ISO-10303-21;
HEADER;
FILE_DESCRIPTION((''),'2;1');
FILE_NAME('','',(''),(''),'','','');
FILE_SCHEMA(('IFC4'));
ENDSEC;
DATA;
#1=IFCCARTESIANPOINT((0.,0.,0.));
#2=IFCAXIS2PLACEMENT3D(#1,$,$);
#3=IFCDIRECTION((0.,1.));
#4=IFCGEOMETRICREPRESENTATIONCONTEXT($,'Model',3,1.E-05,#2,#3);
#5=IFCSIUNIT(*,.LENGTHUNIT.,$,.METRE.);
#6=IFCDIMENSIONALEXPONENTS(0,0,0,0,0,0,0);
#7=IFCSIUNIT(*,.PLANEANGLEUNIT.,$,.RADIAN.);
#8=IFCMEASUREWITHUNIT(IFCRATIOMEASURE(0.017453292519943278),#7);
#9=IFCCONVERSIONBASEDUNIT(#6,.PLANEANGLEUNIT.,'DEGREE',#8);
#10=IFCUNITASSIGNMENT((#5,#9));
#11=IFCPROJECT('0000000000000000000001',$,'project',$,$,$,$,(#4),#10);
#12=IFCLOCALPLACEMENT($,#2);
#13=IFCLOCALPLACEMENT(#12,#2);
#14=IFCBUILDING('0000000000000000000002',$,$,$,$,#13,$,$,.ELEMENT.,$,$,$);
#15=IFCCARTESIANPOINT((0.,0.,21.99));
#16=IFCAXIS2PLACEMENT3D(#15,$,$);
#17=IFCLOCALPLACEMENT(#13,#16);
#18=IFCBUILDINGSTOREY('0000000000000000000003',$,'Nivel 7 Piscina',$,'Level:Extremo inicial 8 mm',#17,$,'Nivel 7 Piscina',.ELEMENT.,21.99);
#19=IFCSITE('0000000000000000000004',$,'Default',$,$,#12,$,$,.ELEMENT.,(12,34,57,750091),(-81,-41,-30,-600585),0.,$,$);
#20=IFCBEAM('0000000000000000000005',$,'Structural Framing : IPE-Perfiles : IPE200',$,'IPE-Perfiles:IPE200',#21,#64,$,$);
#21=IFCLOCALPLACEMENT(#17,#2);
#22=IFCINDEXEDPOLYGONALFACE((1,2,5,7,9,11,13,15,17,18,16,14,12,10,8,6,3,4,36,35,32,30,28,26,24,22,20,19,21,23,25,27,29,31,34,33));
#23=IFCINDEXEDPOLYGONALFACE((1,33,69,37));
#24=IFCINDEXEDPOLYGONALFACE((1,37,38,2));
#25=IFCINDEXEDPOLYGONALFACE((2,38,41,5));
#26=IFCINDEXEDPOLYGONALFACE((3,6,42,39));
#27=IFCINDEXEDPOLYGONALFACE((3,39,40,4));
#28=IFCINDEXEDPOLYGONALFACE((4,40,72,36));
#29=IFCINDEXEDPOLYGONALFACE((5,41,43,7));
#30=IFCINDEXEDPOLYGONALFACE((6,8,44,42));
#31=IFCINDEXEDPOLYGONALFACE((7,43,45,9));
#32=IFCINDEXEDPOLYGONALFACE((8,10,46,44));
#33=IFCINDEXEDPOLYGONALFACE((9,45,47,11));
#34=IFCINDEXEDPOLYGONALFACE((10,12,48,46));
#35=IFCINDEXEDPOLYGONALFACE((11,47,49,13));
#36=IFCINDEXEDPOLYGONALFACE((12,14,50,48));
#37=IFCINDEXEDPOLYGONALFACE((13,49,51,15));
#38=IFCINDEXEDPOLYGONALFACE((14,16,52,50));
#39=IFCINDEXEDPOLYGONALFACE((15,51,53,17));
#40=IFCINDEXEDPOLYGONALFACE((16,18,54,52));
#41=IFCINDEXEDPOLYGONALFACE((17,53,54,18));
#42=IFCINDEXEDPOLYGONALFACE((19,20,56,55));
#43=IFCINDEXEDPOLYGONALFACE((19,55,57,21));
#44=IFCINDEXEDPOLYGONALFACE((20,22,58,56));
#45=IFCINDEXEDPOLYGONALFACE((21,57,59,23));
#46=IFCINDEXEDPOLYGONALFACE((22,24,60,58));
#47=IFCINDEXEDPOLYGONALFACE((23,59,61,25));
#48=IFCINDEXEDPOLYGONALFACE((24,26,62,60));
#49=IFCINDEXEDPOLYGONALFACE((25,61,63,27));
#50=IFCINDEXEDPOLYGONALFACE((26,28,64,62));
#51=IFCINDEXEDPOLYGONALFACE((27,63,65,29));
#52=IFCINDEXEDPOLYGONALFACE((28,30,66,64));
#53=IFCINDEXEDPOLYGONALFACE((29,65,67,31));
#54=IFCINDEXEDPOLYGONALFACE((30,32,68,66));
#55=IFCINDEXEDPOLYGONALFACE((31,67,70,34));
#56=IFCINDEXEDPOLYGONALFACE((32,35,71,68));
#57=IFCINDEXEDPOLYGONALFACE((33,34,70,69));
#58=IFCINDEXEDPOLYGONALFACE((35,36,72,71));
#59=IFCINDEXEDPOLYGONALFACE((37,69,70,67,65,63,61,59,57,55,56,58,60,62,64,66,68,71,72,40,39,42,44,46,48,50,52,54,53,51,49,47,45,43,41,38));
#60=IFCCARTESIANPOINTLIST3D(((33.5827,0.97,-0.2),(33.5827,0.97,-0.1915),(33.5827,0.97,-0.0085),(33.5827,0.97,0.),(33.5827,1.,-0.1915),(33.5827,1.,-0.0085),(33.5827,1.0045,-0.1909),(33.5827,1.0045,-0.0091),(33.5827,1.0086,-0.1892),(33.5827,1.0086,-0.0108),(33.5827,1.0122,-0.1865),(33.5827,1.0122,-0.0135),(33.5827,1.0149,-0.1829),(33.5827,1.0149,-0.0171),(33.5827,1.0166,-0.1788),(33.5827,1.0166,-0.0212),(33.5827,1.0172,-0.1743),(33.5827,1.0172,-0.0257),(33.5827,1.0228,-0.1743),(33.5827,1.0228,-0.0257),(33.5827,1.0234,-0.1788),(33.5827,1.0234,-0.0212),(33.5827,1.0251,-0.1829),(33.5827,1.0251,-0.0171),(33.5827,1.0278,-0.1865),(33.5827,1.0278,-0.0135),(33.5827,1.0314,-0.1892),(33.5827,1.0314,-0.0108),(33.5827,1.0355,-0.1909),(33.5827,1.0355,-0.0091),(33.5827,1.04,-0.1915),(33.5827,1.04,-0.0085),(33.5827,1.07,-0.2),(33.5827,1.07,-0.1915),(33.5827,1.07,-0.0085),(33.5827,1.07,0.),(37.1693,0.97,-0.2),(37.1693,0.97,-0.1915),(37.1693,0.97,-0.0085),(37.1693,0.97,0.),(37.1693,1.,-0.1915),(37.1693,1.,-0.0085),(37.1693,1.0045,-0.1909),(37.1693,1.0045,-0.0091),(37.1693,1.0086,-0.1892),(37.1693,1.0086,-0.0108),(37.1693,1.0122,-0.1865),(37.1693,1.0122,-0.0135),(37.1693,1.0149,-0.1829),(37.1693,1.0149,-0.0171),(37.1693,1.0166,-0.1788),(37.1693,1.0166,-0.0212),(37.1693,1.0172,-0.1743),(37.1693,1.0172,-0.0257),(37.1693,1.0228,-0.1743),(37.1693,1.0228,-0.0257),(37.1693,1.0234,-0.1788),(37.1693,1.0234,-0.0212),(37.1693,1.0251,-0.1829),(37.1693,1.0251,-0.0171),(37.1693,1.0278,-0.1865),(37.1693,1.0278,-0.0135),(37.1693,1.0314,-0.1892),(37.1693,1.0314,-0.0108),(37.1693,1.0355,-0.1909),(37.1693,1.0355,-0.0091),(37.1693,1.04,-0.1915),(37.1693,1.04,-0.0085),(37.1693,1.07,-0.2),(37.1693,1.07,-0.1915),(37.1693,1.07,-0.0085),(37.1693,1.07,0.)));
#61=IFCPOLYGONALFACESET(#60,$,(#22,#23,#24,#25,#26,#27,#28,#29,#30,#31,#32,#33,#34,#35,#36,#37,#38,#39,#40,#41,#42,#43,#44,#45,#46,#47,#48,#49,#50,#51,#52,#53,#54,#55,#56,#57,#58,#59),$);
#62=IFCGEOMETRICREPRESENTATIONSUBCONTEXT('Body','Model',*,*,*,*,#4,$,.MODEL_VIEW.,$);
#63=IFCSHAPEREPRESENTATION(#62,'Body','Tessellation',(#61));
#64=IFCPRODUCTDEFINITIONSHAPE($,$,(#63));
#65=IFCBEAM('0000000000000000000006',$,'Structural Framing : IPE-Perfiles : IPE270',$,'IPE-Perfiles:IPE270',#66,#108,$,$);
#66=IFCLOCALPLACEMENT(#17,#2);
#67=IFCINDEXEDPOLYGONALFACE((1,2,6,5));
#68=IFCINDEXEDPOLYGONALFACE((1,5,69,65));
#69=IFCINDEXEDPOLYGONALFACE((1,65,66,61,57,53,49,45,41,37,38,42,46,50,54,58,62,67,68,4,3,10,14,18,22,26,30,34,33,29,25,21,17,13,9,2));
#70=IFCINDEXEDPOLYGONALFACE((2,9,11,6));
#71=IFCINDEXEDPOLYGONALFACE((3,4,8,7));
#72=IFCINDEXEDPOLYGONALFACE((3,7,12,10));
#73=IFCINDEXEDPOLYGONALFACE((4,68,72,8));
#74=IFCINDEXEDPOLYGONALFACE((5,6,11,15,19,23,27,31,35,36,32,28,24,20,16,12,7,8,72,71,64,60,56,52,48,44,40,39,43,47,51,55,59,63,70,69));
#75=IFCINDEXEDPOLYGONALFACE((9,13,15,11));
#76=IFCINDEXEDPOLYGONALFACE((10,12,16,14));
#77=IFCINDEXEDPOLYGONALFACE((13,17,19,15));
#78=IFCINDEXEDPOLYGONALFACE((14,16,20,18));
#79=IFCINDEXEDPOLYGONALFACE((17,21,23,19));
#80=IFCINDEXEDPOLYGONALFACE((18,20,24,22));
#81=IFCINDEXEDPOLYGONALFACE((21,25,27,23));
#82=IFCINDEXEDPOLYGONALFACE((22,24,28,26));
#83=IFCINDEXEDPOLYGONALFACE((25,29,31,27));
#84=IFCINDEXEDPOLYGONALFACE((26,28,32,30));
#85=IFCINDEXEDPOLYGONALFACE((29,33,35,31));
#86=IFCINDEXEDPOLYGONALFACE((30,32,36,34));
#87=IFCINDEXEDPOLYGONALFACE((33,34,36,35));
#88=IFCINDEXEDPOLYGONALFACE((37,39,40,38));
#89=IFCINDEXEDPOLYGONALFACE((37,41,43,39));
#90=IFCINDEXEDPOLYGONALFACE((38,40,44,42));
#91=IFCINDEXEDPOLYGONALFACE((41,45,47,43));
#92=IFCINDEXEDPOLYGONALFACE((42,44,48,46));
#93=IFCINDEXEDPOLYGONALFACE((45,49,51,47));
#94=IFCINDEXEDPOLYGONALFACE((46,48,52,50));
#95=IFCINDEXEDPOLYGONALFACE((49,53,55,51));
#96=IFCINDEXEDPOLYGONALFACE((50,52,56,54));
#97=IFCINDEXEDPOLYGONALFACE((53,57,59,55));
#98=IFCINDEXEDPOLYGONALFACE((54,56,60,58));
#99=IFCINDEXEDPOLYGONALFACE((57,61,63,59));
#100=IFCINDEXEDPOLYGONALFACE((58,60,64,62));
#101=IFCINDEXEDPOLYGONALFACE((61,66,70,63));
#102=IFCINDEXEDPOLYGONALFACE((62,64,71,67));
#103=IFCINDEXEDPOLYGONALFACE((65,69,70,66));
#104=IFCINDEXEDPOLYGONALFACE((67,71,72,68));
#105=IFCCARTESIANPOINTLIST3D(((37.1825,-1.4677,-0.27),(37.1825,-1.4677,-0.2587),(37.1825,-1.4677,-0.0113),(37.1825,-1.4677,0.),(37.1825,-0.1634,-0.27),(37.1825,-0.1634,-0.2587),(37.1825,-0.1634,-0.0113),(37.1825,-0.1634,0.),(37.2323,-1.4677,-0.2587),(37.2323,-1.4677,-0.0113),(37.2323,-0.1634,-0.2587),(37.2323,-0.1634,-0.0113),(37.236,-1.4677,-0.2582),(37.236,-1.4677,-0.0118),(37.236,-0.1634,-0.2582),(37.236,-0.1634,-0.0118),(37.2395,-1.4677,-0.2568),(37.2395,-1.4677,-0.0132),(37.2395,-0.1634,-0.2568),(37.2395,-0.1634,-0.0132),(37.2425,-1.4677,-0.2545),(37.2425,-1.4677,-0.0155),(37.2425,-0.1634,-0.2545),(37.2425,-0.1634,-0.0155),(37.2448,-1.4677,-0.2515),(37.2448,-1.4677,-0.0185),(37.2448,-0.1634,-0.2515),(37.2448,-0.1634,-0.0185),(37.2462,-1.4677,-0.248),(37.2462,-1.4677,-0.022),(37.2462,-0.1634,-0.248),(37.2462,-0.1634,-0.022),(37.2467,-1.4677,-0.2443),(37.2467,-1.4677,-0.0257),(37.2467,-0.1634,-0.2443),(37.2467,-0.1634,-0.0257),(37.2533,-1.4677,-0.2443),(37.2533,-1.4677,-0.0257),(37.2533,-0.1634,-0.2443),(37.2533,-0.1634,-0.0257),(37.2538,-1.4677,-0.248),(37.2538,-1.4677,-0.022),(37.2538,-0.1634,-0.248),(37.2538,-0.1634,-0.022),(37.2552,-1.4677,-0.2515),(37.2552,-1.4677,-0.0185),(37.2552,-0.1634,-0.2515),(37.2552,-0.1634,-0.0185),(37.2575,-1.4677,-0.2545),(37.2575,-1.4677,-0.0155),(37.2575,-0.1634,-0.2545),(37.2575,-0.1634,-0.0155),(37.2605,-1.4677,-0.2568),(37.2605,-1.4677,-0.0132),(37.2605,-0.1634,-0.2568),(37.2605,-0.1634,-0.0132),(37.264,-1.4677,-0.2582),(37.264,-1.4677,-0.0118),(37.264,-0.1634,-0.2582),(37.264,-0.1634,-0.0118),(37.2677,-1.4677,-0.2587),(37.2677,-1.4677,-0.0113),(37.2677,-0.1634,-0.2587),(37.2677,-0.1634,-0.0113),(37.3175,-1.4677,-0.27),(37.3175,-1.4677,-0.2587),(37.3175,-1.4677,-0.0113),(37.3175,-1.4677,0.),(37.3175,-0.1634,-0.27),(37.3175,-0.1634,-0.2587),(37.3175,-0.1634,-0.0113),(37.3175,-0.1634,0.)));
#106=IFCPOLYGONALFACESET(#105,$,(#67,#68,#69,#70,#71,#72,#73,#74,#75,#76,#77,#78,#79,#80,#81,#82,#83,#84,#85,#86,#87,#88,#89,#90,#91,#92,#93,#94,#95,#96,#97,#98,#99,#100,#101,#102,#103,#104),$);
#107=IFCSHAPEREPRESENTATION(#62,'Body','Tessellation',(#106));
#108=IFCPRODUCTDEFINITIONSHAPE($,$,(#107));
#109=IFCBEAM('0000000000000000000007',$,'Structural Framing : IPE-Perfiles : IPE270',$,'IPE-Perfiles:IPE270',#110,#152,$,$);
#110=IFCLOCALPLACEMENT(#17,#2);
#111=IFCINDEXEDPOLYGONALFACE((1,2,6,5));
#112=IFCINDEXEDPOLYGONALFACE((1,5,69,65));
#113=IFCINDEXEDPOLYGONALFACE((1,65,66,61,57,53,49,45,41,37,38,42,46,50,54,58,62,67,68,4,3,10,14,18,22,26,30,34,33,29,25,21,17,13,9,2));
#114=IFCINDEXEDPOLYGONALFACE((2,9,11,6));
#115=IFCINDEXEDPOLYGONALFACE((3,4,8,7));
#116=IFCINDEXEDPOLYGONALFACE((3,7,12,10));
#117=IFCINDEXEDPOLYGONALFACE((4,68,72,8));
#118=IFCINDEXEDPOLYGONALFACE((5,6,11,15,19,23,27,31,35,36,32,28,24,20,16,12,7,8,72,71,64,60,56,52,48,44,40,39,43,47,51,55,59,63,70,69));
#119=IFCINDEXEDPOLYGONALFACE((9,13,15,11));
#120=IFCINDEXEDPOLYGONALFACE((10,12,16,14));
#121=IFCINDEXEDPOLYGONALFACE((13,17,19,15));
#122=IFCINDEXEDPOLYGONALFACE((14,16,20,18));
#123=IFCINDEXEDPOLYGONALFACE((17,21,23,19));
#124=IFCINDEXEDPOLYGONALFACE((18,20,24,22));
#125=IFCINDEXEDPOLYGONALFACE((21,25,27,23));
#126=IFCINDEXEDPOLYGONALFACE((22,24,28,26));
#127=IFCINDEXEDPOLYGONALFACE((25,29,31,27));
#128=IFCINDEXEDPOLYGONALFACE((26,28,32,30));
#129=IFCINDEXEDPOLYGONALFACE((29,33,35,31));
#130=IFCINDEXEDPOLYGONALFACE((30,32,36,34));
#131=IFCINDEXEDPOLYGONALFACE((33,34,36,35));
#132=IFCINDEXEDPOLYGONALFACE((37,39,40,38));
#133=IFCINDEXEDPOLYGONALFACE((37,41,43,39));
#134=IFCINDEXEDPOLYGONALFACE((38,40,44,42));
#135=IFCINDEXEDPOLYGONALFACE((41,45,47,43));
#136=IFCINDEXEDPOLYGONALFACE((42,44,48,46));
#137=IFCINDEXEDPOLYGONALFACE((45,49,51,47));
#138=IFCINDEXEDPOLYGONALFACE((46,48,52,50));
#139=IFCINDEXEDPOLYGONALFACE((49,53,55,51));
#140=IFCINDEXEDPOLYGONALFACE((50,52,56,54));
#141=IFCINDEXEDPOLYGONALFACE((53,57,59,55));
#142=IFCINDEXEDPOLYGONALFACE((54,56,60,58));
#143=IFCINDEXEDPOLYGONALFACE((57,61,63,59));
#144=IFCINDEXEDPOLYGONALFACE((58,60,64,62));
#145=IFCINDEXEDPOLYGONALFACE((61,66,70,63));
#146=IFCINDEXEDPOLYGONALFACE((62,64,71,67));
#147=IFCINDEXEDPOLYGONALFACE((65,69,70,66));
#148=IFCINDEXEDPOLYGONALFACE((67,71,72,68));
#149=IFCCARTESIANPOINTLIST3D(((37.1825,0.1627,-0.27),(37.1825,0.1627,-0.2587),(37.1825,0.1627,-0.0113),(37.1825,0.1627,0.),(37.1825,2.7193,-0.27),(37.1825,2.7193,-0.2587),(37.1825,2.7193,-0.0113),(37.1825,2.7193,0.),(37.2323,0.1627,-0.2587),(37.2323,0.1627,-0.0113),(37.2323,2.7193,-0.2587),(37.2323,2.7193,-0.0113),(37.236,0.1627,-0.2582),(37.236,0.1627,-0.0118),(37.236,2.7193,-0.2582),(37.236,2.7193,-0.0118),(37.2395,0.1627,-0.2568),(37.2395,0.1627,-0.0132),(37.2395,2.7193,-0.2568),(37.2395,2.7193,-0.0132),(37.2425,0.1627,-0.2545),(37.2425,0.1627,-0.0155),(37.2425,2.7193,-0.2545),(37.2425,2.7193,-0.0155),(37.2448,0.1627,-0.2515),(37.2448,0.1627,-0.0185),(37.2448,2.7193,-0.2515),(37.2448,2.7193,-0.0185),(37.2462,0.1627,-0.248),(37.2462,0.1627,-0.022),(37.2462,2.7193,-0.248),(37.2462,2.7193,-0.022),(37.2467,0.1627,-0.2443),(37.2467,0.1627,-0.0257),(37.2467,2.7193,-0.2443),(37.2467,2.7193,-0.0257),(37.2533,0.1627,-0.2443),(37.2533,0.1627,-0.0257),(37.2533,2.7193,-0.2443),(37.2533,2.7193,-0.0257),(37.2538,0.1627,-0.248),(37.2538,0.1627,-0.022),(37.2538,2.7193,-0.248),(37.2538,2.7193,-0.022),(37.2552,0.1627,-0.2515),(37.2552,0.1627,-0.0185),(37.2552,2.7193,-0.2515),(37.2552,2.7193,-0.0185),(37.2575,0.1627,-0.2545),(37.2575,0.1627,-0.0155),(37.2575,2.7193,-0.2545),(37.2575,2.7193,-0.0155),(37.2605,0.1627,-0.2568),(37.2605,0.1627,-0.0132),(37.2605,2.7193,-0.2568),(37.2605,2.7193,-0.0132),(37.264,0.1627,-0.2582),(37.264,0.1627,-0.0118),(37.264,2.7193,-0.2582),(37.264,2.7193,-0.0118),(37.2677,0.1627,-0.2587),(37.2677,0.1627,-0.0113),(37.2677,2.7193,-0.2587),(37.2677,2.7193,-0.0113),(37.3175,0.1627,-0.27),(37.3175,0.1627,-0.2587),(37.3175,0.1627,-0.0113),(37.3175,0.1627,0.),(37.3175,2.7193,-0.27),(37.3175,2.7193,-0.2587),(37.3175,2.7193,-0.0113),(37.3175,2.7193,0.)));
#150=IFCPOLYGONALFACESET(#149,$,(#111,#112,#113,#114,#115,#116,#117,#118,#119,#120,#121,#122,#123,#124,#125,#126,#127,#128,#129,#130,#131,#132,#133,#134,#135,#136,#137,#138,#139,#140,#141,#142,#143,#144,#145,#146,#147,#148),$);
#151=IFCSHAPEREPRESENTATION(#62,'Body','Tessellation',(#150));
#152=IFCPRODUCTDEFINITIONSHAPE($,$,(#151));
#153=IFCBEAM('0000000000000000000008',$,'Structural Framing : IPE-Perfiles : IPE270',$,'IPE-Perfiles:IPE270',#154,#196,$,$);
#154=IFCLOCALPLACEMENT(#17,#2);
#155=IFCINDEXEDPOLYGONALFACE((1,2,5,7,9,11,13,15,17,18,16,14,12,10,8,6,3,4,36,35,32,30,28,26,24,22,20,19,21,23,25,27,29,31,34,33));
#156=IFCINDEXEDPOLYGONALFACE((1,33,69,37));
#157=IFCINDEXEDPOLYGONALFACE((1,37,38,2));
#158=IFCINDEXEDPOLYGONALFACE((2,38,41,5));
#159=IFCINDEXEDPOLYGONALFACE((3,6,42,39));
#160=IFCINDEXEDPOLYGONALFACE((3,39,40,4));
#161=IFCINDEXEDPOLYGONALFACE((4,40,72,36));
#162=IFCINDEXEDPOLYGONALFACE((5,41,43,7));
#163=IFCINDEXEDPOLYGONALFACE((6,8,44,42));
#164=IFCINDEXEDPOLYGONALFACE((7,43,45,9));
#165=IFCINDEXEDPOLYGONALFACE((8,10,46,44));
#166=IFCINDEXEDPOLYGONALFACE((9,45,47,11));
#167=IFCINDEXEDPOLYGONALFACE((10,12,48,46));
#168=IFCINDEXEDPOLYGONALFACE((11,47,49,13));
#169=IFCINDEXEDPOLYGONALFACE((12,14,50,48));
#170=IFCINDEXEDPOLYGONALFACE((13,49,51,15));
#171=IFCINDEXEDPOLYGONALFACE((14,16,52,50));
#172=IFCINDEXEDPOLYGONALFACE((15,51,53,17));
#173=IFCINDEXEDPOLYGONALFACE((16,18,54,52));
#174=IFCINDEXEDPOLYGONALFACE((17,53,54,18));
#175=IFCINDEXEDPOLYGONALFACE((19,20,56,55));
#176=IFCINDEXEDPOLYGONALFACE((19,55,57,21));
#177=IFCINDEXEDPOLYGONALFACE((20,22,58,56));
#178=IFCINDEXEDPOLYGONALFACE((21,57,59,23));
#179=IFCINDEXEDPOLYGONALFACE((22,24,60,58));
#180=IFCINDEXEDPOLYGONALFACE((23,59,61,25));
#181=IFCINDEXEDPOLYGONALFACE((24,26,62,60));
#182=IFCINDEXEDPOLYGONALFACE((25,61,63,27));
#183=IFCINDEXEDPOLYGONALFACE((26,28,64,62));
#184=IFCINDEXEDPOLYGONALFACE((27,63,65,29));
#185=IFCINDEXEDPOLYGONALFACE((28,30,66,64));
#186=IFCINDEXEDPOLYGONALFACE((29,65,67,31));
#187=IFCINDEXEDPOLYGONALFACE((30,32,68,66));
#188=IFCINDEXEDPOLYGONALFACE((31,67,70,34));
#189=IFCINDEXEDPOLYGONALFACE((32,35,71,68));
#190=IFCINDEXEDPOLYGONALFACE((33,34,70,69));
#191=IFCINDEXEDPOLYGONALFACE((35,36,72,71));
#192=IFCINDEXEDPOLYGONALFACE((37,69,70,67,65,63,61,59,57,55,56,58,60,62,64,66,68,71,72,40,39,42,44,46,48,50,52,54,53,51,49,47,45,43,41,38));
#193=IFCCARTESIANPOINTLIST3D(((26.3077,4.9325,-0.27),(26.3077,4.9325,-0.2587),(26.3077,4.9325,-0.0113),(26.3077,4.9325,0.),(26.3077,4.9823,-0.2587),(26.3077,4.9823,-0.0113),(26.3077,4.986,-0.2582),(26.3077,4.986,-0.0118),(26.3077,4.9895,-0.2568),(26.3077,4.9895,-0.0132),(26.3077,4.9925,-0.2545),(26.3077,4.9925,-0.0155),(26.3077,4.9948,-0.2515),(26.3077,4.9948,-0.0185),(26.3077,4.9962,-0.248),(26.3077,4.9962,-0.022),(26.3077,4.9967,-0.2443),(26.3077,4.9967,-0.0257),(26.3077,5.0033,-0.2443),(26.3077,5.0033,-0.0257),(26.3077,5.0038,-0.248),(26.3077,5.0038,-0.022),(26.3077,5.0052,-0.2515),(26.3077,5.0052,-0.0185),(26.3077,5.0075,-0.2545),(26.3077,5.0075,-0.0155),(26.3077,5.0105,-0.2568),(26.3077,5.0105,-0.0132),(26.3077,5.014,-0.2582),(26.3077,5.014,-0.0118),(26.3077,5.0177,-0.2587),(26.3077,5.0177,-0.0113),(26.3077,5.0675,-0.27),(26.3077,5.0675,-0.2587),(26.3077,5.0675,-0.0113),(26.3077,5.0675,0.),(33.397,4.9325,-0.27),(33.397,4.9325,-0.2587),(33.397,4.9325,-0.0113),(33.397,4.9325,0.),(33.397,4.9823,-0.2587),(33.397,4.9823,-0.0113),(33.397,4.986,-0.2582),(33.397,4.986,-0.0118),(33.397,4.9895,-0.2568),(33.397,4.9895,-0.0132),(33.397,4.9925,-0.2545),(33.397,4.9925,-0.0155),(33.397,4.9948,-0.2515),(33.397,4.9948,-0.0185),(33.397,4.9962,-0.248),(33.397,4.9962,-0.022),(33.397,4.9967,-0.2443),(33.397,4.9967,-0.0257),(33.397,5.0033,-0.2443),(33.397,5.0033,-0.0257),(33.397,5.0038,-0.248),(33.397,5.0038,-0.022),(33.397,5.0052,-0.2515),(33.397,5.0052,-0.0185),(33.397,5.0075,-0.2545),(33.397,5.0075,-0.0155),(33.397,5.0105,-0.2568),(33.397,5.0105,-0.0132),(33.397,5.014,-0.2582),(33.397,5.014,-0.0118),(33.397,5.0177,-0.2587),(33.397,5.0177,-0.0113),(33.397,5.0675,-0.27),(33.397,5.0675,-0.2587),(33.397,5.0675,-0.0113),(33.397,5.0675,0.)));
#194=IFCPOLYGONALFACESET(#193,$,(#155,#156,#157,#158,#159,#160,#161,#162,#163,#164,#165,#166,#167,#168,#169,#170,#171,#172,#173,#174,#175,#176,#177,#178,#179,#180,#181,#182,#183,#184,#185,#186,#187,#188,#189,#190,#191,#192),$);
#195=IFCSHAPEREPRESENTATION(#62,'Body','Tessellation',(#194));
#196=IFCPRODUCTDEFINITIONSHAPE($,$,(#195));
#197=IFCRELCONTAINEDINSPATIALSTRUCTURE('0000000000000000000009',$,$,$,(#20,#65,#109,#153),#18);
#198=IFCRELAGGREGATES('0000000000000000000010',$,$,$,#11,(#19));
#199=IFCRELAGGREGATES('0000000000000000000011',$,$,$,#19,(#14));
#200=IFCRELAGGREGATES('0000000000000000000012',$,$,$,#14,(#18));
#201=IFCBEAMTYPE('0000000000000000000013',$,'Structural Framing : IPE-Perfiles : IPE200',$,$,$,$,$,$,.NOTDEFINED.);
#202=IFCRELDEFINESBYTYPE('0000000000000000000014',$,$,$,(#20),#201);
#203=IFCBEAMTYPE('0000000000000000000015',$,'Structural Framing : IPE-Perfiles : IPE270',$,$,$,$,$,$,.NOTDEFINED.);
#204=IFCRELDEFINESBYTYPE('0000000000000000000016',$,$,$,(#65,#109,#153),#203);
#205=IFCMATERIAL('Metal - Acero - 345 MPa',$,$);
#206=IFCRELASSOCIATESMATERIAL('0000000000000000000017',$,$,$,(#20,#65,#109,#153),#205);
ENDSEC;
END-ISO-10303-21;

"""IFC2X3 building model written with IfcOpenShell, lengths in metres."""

from ifc_helpers import new_model, entity, si_unit, converted_unit, direction, frame, frame_2d, origin, place, context, subcontext, project, spatial, i_section, extrude, material, type_object, element, save


model = new_model("IFC2X3")

# Units and contexts
model_context = context("Model", 3, precision=1e-05, world=origin(), true_north=direction((0.0, 1.0)))
body_context = subcontext(model_context, "Body", "Model", "MODEL_VIEW")
ifc_project = project(units=[si_unit("LENGTHUNIT", "METRE"), converted_unit("PLANEANGLEUNIT", "DEGREE", entity("IfcRatioMeasure", 0.017453292519943278), si_unit("PLANEANGLEUNIT", "RADIAN"), dimensions=[0, 0, 0, 0, 0, 0, 0])], contexts=[model_context])

# Site, building, storey
site_placement = place(None, origin())
site = spatial("IfcSite", under=ifc_project, at=site_placement, Name="Default", CompositionType="ELEMENT", RefLatitude=(12, 34, 57, 750091), RefLongitude=(-81, -41, -30, -600585), RefElevation=0.0)
building_placement = place(site_placement, origin())
building = spatial("IfcBuilding", under=site, at=building_placement, CompositionType="ELEMENT")
storey_placement = place(building_placement, frame((0.0, 0.0, 21.99)))
storey = spatial("IfcBuildingStorey", under=building, at=storey_placement, Name="Nivel 7 Piscina", ObjectType="Level:Extremo inicial 8 mm", LongName="Nivel 7 Piscina", CompositionType="ELEMENT", Elevation=21.99)

# Shared definitions
ifc_material = material(Name="Metal - Acero - 345 MPa")

# Beams
beam_type_1 = type_object("IfcBeamType", Name="Structural Framing : IPE-Perfiles : IPE200", PredefinedType="NOTDEFINED")
beam_1_placement = place(storey_placement, frame((33.495, 1.02, 0.0)))
element("IfcBeam", 1, at=beam_1_placement, inside=storey, type_object=beam_type_1, material=ifc_material, Name="Structural Framing : IPE-Perfiles : IPE200", ObjectType="IPE-Perfiles:IPE200", context=body_context, shape_type="SweptSolid", body=[
    extrude(i_section(OverallWidth=0.1, OverallDepth=0.2, WebThickness=0.0056, FlangeThickness=0.0085, FilletRadius=0.0172, at=frame_2d((0.0, 0.0), x_axis=(0.0, 1.0))), frame((0.0877, 0.0, -0.1), z_axis=(1.0, 0.0, 0.0), x_axis=(0.0, 0.0, -1.0)), (0.0, 0.0, 1.0), 3.5866),
])
beam_type_2 = type_object("IfcBeamType", Name="Structural Framing : IPE-Perfiles : IPE270", PredefinedType="NOTDEFINED")
beam_2_placement = place(storey_placement, frame((37.25, -1.4, 0.0), z_axis=(0.0, 0.0, 1.0), x_axis=(0.0, 1.0, 0.0)))
element("IfcBeam", 2, at=beam_2_placement, inside=storey, type_object=beam_type_2, material=ifc_material, Name="Structural Framing : IPE-Perfiles : IPE270", ObjectType="IPE-Perfiles:IPE270", context=body_context, shape_type="SweptSolid", body=[
    extrude(i_section(OverallWidth=0.135, OverallDepth=0.27, WebThickness=0.0066, FlangeThickness=0.0113, FilletRadius=0.0144, at=frame_2d((0.0, 0.0), x_axis=(0.0, 1.0))), frame((-0.0677, 0.0, -0.135), z_axis=(1.0, 0.0, 0.0), x_axis=(0.0, 0.0, -1.0)), (0.0, 0.0, 1.0), 1.3043),
])
beam_3_placement = place(storey_placement, frame((37.25, 0.0, 0.0), z_axis=(0.0, 0.0, 1.0), x_axis=(0.0, 1.0, 0.0)))
element("IfcBeam", 3, at=beam_3_placement, inside=storey, type_object=beam_type_2, material=ifc_material, Name="Structural Framing : IPE-Perfiles : IPE270", ObjectType="IPE-Perfiles:IPE270", context=body_context, shape_type="SweptSolid", body=[
    extrude(i_section(OverallWidth=0.135, OverallDepth=0.27, WebThickness=0.0066, FlangeThickness=0.0113, FilletRadius=0.0144, at=frame_2d((0.0, 0.0), x_axis=(0.0, 1.0))), frame((0.1627, 0.0, -0.135), z_axis=(1.0, 0.0, 0.0), x_axis=(0.0, 0.0, -1.0)), (0.0, 0.0, 1.0), 2.5566),
])
beam_4_placement = place(storey_placement, frame((26.3075, 5.0, 0.0)))
element("IfcBeam", 4, at=beam_4_placement, inside=storey, type_object=beam_type_2, material=ifc_material, Name="Structural Framing : IPE-Perfiles : IPE270", ObjectType="IPE-Perfiles:IPE270", context=body_context, shape_type="SweptSolid", body=[
    extrude(i_section(OverallWidth=0.135, OverallDepth=0.27, WebThickness=0.0066, FlangeThickness=0.0113, FilletRadius=0.0144, at=frame_2d((0.0, 0.0), x_axis=(0.0, 1.0))), frame((0.0002, 0.0, -0.135), z_axis=(1.0, 0.0, 0.0), x_axis=(0.0, 0.0, -1.0)), (0.0, 0.0, 1.0), 7.0893),
])

save(model, "model.ifc")
